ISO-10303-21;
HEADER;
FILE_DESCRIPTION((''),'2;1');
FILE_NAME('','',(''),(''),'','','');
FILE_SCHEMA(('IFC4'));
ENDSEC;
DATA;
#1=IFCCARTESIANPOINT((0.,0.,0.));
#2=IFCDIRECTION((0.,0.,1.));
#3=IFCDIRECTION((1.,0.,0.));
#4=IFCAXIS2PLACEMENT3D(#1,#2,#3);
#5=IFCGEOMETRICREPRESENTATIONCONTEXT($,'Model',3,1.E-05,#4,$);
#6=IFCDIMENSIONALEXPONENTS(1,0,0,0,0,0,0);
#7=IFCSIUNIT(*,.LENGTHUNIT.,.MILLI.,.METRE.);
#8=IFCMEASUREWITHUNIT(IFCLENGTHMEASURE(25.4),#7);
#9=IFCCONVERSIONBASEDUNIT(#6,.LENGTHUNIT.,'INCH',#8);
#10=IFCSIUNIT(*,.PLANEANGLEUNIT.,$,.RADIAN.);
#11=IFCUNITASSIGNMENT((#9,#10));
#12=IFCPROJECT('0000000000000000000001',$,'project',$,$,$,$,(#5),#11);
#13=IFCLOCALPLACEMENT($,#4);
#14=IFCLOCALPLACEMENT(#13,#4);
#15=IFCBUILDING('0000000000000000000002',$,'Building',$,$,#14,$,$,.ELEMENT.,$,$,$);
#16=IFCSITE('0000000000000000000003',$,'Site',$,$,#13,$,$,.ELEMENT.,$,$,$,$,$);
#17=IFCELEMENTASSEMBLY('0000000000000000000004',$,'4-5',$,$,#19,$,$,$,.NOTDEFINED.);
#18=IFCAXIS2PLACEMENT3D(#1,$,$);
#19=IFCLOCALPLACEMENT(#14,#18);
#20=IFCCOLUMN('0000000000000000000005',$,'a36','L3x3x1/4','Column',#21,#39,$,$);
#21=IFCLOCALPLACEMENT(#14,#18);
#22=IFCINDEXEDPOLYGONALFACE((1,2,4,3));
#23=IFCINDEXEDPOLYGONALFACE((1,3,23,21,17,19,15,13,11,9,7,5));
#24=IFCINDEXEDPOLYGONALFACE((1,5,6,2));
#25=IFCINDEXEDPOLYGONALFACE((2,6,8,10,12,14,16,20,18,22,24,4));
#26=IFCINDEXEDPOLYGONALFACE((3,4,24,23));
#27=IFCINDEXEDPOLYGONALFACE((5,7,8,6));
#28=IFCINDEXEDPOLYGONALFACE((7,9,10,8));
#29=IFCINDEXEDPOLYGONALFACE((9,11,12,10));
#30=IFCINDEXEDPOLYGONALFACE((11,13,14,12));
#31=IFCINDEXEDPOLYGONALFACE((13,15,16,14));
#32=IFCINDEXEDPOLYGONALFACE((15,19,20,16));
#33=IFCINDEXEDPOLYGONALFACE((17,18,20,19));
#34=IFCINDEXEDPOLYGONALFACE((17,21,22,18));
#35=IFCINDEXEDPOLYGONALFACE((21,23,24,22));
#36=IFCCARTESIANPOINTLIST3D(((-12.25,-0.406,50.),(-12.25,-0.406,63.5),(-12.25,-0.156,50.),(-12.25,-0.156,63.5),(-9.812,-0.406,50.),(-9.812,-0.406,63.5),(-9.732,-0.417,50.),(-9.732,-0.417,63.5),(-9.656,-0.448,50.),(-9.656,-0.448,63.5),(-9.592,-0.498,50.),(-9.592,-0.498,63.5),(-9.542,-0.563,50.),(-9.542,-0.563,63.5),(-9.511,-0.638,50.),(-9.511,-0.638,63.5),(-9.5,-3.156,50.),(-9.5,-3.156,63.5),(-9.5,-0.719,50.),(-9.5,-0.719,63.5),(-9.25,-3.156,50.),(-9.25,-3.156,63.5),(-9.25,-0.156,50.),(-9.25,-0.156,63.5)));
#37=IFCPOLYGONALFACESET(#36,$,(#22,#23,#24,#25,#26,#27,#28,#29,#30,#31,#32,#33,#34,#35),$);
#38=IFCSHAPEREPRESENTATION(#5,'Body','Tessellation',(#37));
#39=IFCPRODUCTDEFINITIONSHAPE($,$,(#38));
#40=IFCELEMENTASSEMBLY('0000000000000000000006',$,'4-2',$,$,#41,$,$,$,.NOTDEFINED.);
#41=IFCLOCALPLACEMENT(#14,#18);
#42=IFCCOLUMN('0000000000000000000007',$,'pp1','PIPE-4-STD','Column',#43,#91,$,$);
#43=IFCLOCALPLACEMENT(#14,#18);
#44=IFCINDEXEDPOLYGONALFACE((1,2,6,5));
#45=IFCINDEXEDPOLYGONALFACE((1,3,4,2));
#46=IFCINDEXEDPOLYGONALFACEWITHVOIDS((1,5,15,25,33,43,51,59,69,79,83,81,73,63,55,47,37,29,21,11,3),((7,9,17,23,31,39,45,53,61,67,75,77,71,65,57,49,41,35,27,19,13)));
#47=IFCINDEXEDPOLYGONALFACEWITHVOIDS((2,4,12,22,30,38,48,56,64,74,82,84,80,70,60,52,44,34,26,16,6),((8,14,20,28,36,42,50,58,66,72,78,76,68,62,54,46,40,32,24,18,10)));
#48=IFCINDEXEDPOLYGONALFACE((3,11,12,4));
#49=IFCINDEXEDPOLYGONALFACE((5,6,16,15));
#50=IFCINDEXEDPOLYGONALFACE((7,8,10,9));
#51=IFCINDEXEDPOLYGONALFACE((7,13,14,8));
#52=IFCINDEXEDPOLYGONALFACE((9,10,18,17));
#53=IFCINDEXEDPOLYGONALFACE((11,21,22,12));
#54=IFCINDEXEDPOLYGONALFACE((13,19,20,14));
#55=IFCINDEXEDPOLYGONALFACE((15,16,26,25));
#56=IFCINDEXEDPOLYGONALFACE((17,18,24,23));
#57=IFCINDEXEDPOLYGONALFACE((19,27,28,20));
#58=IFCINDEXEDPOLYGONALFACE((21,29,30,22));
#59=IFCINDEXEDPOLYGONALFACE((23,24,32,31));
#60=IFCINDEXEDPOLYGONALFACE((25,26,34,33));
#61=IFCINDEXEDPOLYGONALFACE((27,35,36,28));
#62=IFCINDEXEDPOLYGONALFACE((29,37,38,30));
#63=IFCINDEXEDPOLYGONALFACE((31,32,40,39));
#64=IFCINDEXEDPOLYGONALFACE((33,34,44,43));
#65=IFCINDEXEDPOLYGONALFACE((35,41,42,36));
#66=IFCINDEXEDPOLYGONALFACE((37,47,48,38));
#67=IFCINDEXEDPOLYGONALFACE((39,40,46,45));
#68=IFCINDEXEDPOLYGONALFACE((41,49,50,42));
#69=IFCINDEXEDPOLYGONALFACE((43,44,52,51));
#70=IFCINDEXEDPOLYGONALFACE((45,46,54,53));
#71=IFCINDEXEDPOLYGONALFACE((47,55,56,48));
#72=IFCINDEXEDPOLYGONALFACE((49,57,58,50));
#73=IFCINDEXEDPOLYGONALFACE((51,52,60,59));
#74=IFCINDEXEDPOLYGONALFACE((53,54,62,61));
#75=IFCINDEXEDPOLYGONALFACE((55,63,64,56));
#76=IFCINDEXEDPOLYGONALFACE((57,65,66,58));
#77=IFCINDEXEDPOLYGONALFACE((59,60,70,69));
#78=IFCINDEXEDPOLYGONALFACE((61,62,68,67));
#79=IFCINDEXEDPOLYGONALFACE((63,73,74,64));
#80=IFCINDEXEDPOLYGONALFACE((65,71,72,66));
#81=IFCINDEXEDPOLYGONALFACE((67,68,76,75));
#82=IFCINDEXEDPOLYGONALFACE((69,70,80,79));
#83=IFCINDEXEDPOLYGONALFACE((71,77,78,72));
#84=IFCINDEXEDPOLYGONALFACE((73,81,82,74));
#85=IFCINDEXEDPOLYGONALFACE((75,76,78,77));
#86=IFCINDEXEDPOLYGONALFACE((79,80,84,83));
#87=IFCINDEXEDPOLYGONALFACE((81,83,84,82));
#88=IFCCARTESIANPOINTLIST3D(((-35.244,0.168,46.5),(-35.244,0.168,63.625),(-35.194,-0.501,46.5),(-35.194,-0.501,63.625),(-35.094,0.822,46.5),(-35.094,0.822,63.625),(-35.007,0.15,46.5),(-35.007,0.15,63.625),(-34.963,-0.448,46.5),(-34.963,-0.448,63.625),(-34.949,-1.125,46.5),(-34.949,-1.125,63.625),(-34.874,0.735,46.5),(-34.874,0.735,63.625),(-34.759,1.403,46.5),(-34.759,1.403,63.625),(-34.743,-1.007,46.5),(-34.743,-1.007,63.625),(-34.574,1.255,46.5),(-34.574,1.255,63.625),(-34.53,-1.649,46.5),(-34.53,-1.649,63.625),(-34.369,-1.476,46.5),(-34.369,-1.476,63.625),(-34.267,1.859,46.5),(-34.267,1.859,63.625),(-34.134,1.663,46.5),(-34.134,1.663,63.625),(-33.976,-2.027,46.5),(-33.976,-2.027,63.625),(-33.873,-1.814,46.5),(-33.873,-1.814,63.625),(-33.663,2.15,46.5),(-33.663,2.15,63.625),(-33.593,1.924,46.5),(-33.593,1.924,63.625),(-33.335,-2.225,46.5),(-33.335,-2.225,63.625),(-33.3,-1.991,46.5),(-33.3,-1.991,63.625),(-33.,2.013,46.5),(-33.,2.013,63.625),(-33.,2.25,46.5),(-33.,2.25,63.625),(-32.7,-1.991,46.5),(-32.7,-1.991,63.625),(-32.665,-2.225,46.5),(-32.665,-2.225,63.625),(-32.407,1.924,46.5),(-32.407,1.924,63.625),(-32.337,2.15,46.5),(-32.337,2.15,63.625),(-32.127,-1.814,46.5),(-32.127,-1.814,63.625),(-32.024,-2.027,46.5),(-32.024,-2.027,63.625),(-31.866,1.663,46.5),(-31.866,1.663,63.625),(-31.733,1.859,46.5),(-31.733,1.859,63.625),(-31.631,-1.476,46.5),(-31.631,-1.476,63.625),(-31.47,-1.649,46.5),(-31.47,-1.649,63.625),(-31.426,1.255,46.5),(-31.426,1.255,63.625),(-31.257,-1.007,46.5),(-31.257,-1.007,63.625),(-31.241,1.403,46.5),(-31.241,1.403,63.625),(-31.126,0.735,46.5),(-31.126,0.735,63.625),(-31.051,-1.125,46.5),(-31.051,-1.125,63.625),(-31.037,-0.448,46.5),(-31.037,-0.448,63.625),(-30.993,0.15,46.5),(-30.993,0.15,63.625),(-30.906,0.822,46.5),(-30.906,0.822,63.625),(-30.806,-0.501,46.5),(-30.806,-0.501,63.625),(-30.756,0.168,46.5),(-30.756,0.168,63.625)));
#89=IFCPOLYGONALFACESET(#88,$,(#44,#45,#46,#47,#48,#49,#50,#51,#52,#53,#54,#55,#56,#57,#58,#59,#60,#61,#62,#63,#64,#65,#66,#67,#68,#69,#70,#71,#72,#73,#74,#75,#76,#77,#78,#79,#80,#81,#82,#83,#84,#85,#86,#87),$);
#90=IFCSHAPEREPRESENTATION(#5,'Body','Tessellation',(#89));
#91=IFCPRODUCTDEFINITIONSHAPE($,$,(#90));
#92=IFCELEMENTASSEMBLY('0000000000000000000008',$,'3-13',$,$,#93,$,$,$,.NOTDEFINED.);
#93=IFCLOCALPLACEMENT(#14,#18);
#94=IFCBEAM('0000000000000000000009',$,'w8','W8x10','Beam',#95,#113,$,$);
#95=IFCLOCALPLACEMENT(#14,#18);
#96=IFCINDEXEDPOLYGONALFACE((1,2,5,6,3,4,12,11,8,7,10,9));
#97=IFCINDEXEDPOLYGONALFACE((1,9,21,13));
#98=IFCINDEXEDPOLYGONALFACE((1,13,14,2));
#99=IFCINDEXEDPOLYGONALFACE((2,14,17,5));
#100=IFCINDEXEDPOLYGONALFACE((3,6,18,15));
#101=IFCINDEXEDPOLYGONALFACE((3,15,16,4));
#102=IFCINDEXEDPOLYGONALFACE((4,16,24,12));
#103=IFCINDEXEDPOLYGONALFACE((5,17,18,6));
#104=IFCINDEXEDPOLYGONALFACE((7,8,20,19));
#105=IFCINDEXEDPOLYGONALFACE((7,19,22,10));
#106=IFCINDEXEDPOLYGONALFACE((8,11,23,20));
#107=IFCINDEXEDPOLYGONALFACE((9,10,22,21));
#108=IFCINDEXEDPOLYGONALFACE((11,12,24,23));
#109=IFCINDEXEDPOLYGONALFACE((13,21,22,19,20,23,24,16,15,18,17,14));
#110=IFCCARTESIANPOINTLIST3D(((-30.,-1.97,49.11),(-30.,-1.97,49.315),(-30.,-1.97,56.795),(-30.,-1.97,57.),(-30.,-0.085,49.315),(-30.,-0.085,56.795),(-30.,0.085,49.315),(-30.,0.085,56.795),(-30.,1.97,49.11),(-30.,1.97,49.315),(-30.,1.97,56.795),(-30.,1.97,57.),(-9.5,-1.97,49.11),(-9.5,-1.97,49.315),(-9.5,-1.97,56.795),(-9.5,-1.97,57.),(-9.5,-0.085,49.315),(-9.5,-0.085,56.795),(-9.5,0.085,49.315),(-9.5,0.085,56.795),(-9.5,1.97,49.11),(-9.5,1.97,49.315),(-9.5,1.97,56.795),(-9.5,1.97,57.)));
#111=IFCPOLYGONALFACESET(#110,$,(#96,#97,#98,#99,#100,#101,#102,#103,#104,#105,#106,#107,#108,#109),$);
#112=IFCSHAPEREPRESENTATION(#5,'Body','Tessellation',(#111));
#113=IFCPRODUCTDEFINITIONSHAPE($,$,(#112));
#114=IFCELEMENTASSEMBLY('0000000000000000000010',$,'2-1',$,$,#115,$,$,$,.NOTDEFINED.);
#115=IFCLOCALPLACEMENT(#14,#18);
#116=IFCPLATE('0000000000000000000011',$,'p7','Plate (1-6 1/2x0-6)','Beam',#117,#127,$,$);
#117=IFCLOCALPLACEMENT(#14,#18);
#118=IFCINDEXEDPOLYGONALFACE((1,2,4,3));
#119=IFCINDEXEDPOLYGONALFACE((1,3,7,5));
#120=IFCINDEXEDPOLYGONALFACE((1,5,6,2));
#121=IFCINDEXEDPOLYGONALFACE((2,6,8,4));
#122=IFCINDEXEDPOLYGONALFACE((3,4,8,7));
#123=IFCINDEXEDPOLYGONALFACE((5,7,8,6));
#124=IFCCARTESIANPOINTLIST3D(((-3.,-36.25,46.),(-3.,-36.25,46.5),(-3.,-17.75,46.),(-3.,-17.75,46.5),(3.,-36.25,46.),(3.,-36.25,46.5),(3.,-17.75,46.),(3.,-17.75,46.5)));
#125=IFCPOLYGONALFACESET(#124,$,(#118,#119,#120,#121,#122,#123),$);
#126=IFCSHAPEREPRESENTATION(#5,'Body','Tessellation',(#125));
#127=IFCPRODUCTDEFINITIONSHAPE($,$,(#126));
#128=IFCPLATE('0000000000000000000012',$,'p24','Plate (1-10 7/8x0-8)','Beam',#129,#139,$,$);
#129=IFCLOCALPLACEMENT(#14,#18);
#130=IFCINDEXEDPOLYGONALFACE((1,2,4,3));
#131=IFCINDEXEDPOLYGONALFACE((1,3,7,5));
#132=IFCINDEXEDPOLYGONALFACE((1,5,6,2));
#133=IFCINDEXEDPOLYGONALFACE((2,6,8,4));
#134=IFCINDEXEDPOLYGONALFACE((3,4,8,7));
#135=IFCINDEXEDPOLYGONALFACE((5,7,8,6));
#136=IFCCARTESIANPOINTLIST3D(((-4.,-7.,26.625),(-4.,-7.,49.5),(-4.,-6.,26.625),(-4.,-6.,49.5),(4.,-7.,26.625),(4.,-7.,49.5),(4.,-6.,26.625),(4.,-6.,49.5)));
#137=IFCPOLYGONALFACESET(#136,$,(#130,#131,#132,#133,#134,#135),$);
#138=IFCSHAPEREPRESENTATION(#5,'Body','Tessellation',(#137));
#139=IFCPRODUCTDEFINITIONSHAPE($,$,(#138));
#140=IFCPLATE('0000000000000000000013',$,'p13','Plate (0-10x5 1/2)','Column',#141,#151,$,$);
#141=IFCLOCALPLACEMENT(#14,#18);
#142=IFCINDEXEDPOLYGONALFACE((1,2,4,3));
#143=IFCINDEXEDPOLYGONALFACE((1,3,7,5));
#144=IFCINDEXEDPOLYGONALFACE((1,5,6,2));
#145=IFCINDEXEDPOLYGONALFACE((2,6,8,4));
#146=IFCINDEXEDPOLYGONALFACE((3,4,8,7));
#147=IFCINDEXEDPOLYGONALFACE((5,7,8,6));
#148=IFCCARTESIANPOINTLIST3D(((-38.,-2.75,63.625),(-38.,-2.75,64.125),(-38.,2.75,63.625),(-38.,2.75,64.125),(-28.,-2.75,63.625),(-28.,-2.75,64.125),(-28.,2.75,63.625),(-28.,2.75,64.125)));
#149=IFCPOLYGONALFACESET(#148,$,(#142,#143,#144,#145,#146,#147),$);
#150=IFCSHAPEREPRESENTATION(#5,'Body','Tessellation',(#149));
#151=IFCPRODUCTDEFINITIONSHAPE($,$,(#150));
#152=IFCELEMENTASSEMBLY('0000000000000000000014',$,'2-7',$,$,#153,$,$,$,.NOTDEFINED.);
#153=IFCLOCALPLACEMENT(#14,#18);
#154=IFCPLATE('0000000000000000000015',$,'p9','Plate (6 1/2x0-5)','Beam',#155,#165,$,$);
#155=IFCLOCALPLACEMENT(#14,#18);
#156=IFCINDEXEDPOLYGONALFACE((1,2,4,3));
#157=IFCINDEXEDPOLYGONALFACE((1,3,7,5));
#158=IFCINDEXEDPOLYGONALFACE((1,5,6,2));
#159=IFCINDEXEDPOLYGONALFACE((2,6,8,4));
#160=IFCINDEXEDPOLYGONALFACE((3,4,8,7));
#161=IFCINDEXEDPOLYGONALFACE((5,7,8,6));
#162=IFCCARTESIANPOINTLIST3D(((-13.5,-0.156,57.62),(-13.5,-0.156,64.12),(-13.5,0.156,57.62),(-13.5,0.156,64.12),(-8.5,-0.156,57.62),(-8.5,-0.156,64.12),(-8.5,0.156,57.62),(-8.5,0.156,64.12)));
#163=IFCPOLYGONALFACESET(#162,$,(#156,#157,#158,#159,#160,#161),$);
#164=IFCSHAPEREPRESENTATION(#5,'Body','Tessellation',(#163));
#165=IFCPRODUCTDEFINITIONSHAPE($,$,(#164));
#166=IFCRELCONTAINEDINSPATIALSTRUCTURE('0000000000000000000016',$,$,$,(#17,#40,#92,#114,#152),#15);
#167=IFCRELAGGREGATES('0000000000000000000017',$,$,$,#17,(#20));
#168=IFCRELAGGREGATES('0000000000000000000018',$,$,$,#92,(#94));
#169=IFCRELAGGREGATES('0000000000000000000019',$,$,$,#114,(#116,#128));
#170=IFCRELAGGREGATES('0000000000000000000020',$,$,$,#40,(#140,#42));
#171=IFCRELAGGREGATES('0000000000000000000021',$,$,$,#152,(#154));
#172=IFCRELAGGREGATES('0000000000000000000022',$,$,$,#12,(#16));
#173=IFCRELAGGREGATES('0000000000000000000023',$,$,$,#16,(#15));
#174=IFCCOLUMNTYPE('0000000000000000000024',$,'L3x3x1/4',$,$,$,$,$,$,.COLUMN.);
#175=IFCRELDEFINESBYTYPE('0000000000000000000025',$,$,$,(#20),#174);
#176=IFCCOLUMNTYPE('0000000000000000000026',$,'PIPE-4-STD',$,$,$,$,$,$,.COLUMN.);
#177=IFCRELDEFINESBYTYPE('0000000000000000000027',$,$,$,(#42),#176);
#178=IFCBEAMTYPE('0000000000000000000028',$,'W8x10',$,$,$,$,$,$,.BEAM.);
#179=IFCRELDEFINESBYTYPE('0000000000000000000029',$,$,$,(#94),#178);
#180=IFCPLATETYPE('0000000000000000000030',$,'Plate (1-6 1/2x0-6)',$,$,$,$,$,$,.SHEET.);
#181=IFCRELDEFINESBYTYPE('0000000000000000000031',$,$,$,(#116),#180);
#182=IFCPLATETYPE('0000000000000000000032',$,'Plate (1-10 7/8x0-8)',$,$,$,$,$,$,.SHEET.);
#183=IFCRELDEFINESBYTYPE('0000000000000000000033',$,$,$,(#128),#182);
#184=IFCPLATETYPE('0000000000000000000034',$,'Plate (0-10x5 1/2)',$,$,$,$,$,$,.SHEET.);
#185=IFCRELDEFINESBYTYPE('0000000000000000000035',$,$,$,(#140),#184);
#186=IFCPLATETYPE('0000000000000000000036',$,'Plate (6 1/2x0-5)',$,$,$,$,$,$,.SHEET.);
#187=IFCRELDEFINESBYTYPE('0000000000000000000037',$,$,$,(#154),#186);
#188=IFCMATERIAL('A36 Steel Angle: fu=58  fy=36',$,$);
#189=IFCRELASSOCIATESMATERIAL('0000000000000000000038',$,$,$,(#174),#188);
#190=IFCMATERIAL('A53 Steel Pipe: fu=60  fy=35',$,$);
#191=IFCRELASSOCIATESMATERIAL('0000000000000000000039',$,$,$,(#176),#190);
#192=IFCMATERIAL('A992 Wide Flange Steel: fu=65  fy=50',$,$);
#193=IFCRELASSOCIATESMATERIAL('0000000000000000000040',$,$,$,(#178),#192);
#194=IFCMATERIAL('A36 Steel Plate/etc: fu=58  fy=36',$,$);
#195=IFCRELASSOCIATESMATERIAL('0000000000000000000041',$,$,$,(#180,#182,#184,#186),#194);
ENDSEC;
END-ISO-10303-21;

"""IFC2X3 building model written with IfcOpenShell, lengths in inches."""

from ifc_helpers import new_model, entity, si_unit, converted_unit, frame, frame_2d, origin_with_axes, origin_2d_with_axis, place, context, project, spatial, polyline, hollow_circle, i_section, l_section, outline, extrude, source, transform, mapped, material, type_object, type_shapes, element, aggregate, save


model = new_model("IFC2X3")

# Units and contexts
model_context = context("Model", 3, precision=1e-05, world=origin_with_axes())
ifc_project = project(units=[converted_unit("LENGTHUNIT", "INCH", entity("IfcLengthMeasure", 25.4), si_unit("LENGTHUNIT", "METRE", prefix="MILLI"), dimensions=[1, 0, 0, 0, 0, 0, 0]), si_unit("PLANEANGLEUNIT", "RADIAN")], contexts=[model_context])

# Site, building
site_placement = place(None, origin_with_axes())
site = spatial("IfcSite", under=ifc_project, at=site_placement, Name="Site", CompositionType="ELEMENT")
building_placement = place(site_placement, origin_with_axes())
building = spatial("IfcBuilding", under=site, at=building_placement, Name="Building", CompositionType="ELEMENT")

# Element assemblies, columns
assembly_1_placement = place(building_placement, frame((-9.25, 0.0, 50.0), z_axis=(-1.0, 0.0, 0.0), x_axis=(0.0, 0.0, 1.0)))
assembly_1 = element("IfcElementAssembly", 1, at=assembly_1_placement, inside=building, Name="4-5", PredefinedType="NOTDEFINED")
ifc_material_1 = material(Name="A36 Steel Angle: fu=58  fy=36")
column_type_1 = type_object("IfcColumnType", Name="L3x3x1/4", PredefinedType="COLUMN", material=ifc_material_1)
shared_shape_1 = source(origin_with_axes(), model_context, "Body", "SweptSolid", [
    extrude(l_section(Depth=3.0, Width=3.0, Thickness=0.25, FilletRadius=0.312, at=frame_2d((1.5, 1.5), x_axis=(1.0, 0.0))), frame((0.0, 0.0, 0.0), z_axis=(1.0, 0.0, 0.0), x_axis=(0.0, 1.0, 0.0)), (0.0, 0.0, 1.0), 13.5),
])
type_shapes(column_type_1, [shared_shape_1])
column_1_placement = place(assembly_1_placement, frame((0.0, -0.156, 0.0), z_axis=(0.0, -1.0, 0.0), x_axis=(1.0, 0.0, 0.0)))
column_1 = element("IfcColumn", 2, at=column_1_placement, type_object=column_type_1, Name="a36", Description="L3x3x1/4", ObjectType="Column", context=model_context, shape_type="MappedRepresentation", body=[
    mapped(shared_shape_1, transform((0.0, 0.0, 0.0), scale=1.0)),
])
aggregate(assembly_1, [column_1])
assembly_2_placement = place(building_placement, frame((-33.0, 0.0, 46.0), z_axis=(-1.0, 0.0, 0.0), x_axis=(0.0, 0.0, 1.0)))
assembly_2 = element("IfcElementAssembly", 3, at=assembly_2_placement, inside=building, Name="4-2", PredefinedType="NOTDEFINED")
ifc_material_2 = material(Name="A53 Steel Pipe: fu=60  fy=35")
column_type_2 = type_object("IfcColumnType", Name="PIPE-4-STD", PredefinedType="COLUMN", material=ifc_material_2)
shared_shape_2 = source(origin_with_axes(), model_context, "Body", "SweptSolid", [
    extrude(hollow_circle(Radius=2.25, WallThickness=0.237, at=origin_2d_with_axis()), frame((0.0, 0.0, 0.0), z_axis=(1.0, 0.0, 0.0), x_axis=(0.0, 1.0, 0.0)), (0.0, 0.0, 1.0), 17.125),
])
type_shapes(column_type_2, [shared_shape_2])
column_2_placement = place(assembly_2_placement, frame((0.5, 0.0, 0.0), z_axis=(0.0, 0.0, 1.0), x_axis=(1.0, 0.0, 0.0)))
column_2 = element("IfcColumn", 4, at=column_2_placement, type_object=column_type_2, Name="pp1", Description="PIPE-4-STD", ObjectType="Column", context=model_context, shape_type="MappedRepresentation", body=[
    mapped(shared_shape_2, transform((0.0, 0.0, 0.0), scale=1.0)),
])

# Element assembly, beam
assembly_3_placement = place(building_placement, frame((-9.25, 0.0, 57.0), z_axis=(0.0, 0.0, 1.0), x_axis=(-1.0, 0.0, 0.0)))
assembly_3 = element("IfcElementAssembly", 5, at=assembly_3_placement, inside=building, Name="3-13", PredefinedType="NOTDEFINED")
ifc_material_3 = material(Name="A992 Wide Flange Steel: fu=65  fy=50")
beam_type = type_object("IfcBeamType", Name="W8x10", PredefinedType="BEAM", material=ifc_material_3)
shared_shape_3 = source(origin_with_axes(), model_context, "Body", "SweptSolid", [
    extrude(i_section(OverallWidth=3.94, OverallDepth=7.89, WebThickness=0.17, FlangeThickness=0.205, at=frame_2d((0.0, -3.945), x_axis=(1.0, 0.0))), frame((0.0, 0.0, 0.0), z_axis=(1.0, 0.0, 0.0), x_axis=(0.0, 1.0, 0.0)), (0.0, 0.0, 1.0), 20.5),
])
type_shapes(beam_type, [shared_shape_3])
beam_placement = place(assembly_3_placement, frame((0.25, 0.0, 0.0), z_axis=(0.0, 0.0, 1.0), x_axis=(1.0, 0.0, 0.0)))
beam = element("IfcBeam", 6, at=beam_placement, type_object=beam_type, Name="w8", Description="W8x10", ObjectType="Beam", context=model_context, shape_type="MappedRepresentation", body=[
    mapped(shared_shape_3, transform((0.0, 0.0, 0.0), scale=1.0)),
])
aggregate(assembly_3, [beam])

# Element assembly, plates
assembly_4_placement = place(building_placement, frame((0.0, 0.0, 46.0), z_axis=(0.0, 0.0, 1.0), x_axis=(0.0, -1.0, 0.0)))
assembly_4 = element("IfcElementAssembly", 7, at=assembly_4_placement, inside=building, Name="2-1", PredefinedType="NOTDEFINED")
ifc_material_4 = material(Name="A36 Steel Plate/etc: fu=58  fy=36")
plate_type_1 = type_object("IfcPlateType", Name="Plate (1-6 1/2x0-6)", PredefinedType="SHEET", material=ifc_material_4)
shared_shape_4 = source(origin_with_axes(), model_context, "Body", "SweptSolid", [
    extrude(outline(polyline([(3.0, -18.5), (-3.0, -18.5), (-3.0, 0.0), (3.0, 0.0), (3.0, -18.5)])), frame((-0.25, 0.0, 0.0), z_axis=(1.0, 0.0, 0.0), x_axis=(0.0, 1.0, 0.0)), (0.0, 0.0, 1.0), 0.5),
])
type_shapes(plate_type_1, [shared_shape_4])
plate_1_placement = place(assembly_4_placement, frame((36.25, 0.0, 0.25), z_axis=(1.0, 0.0, 0.0), x_axis=(0.0, 0.0, -1.0)))
plate_1 = element("IfcPlate", 8, at=plate_1_placement, type_object=plate_type_1, Name="p7", Description="Plate (1-6 1/2x0-6)", ObjectType="Beam", context=model_context, shape_type="MappedRepresentation", body=[
    mapped(shared_shape_4, transform((0.0, 0.0, 0.0), scale=1.0)),
])
plate_type_2 = type_object("IfcPlateType", Name="Plate (1-10 7/8x0-8)", PredefinedType="SHEET", material=ifc_material_4)
shared_shape_5 = source(origin_with_axes(), model_context, "Body", "SweptSolid", [
    extrude(outline(polyline([(4.0, -22.875), (-4.0, -22.875), (-4.0, 0.0), (4.0, 0.0), (4.0, -22.875)])), frame((-0.5, 0.0, 0.0), z_axis=(1.0, 0.0, 0.0), x_axis=(0.0, 1.0, 0.0)), (0.0, 0.0, 1.0), 1.0),
])
type_shapes(plate_type_2, [shared_shape_5])
plate_2_placement = place(assembly_4_placement, frame((6.5, 0.0, 3.5), z_axis=(0.0, 0.0, 1.0), x_axis=(-1.0, 0.0, 0.0)))
plate_2 = element("IfcPlate", 9, at=plate_2_placement, type_object=plate_type_2, Name="p24", Description="Plate (1-10 7/8x0-8)", ObjectType="Beam", context=model_context, shape_type="MappedRepresentation", body=[
    mapped(shared_shape_5, transform((0.0, 0.0, 0.0), scale=1.0)),
])
aggregate(assembly_4, [plate_1, plate_2])

# Plate
plate_type_3 = type_object("IfcPlateType", Name="Plate (0-10x5 1/2)", PredefinedType="SHEET", material=ifc_material_4)
shared_shape_6 = source(origin_with_axes(), model_context, "Body", "SweptSolid", [
    extrude(outline(polyline([(2.75, -5.0), (-2.75, -5.0), (-2.75, 5.0), (2.75, 5.0), (2.75, -5.0)])), frame((-0.25, 0.0, 0.0), z_axis=(1.0, 0.0, 0.0), x_axis=(0.0, 1.0, 0.0)), (0.0, 0.0, 1.0), 0.5),
])
type_shapes(plate_type_3, [shared_shape_6])
plate_3_placement = place(assembly_2_placement, frame((17.875, 0.0, 0.0), z_axis=(0.0, 0.0, -1.0), x_axis=(-1.0, 0.0, 0.0)))
plate_3 = element("IfcPlate", 10, at=plate_3_placement, type_object=plate_type_3, Name="p13", Description="Plate (0-10x5 1/2)", ObjectType="Column", context=model_context, shape_type="MappedRepresentation", body=[
    mapped(shared_shape_6, transform((0.0, 0.0, 0.0), scale=1.0)),
])
aggregate(assembly_2, [plate_3, column_2])

# Element assembly, plate
assembly_5_placement = place(building_placement, frame((0.0, 0.0, 80.0), z_axis=(0.0, 0.0, 1.0), x_axis=(-1.0, 0.0, 0.0)))
assembly_5 = element("IfcElementAssembly", 11, at=assembly_5_placement, inside=building, Name="2-7", PredefinedType="NOTDEFINED")
plate_type_4 = type_object("IfcPlateType", Name="Plate (6 1/2x0-5)", PredefinedType="SHEET", material=ifc_material_4)
shared_shape_7 = source(origin_with_axes(), model_context, "Body", "SweptSolid", [
    extrude(outline(polyline([(0.0, -6.5), (-5.0, -6.5), (-5.0, 0.0), (0.0, 0.0), (0.0, -6.5)])), frame((-0.156, 0.0, 0.0), z_axis=(1.0, 0.0, 0.0), x_axis=(0.0, 1.0, 0.0)), (0.0, 0.0, 1.0), 0.312),
])
type_shapes(plate_type_4, [shared_shape_7])
plate_4_placement = place(assembly_5_placement, frame((13.5, 0.0, -15.88), z_axis=(0.0, 0.0, 1.0), x_axis=(0.0, -1.0, 0.0)))
plate_4 = element("IfcPlate", 12, at=plate_4_placement, type_object=plate_type_4, Name="p9", Description="Plate (6 1/2x0-5)", ObjectType="Beam", context=model_context, shape_type="MappedRepresentation", body=[
    mapped(shared_shape_7, transform((0.0, 0.0, 0.0), scale=1.0)),
])
aggregate(assembly_5, [plate_4])

save(model, "model.ifc")
